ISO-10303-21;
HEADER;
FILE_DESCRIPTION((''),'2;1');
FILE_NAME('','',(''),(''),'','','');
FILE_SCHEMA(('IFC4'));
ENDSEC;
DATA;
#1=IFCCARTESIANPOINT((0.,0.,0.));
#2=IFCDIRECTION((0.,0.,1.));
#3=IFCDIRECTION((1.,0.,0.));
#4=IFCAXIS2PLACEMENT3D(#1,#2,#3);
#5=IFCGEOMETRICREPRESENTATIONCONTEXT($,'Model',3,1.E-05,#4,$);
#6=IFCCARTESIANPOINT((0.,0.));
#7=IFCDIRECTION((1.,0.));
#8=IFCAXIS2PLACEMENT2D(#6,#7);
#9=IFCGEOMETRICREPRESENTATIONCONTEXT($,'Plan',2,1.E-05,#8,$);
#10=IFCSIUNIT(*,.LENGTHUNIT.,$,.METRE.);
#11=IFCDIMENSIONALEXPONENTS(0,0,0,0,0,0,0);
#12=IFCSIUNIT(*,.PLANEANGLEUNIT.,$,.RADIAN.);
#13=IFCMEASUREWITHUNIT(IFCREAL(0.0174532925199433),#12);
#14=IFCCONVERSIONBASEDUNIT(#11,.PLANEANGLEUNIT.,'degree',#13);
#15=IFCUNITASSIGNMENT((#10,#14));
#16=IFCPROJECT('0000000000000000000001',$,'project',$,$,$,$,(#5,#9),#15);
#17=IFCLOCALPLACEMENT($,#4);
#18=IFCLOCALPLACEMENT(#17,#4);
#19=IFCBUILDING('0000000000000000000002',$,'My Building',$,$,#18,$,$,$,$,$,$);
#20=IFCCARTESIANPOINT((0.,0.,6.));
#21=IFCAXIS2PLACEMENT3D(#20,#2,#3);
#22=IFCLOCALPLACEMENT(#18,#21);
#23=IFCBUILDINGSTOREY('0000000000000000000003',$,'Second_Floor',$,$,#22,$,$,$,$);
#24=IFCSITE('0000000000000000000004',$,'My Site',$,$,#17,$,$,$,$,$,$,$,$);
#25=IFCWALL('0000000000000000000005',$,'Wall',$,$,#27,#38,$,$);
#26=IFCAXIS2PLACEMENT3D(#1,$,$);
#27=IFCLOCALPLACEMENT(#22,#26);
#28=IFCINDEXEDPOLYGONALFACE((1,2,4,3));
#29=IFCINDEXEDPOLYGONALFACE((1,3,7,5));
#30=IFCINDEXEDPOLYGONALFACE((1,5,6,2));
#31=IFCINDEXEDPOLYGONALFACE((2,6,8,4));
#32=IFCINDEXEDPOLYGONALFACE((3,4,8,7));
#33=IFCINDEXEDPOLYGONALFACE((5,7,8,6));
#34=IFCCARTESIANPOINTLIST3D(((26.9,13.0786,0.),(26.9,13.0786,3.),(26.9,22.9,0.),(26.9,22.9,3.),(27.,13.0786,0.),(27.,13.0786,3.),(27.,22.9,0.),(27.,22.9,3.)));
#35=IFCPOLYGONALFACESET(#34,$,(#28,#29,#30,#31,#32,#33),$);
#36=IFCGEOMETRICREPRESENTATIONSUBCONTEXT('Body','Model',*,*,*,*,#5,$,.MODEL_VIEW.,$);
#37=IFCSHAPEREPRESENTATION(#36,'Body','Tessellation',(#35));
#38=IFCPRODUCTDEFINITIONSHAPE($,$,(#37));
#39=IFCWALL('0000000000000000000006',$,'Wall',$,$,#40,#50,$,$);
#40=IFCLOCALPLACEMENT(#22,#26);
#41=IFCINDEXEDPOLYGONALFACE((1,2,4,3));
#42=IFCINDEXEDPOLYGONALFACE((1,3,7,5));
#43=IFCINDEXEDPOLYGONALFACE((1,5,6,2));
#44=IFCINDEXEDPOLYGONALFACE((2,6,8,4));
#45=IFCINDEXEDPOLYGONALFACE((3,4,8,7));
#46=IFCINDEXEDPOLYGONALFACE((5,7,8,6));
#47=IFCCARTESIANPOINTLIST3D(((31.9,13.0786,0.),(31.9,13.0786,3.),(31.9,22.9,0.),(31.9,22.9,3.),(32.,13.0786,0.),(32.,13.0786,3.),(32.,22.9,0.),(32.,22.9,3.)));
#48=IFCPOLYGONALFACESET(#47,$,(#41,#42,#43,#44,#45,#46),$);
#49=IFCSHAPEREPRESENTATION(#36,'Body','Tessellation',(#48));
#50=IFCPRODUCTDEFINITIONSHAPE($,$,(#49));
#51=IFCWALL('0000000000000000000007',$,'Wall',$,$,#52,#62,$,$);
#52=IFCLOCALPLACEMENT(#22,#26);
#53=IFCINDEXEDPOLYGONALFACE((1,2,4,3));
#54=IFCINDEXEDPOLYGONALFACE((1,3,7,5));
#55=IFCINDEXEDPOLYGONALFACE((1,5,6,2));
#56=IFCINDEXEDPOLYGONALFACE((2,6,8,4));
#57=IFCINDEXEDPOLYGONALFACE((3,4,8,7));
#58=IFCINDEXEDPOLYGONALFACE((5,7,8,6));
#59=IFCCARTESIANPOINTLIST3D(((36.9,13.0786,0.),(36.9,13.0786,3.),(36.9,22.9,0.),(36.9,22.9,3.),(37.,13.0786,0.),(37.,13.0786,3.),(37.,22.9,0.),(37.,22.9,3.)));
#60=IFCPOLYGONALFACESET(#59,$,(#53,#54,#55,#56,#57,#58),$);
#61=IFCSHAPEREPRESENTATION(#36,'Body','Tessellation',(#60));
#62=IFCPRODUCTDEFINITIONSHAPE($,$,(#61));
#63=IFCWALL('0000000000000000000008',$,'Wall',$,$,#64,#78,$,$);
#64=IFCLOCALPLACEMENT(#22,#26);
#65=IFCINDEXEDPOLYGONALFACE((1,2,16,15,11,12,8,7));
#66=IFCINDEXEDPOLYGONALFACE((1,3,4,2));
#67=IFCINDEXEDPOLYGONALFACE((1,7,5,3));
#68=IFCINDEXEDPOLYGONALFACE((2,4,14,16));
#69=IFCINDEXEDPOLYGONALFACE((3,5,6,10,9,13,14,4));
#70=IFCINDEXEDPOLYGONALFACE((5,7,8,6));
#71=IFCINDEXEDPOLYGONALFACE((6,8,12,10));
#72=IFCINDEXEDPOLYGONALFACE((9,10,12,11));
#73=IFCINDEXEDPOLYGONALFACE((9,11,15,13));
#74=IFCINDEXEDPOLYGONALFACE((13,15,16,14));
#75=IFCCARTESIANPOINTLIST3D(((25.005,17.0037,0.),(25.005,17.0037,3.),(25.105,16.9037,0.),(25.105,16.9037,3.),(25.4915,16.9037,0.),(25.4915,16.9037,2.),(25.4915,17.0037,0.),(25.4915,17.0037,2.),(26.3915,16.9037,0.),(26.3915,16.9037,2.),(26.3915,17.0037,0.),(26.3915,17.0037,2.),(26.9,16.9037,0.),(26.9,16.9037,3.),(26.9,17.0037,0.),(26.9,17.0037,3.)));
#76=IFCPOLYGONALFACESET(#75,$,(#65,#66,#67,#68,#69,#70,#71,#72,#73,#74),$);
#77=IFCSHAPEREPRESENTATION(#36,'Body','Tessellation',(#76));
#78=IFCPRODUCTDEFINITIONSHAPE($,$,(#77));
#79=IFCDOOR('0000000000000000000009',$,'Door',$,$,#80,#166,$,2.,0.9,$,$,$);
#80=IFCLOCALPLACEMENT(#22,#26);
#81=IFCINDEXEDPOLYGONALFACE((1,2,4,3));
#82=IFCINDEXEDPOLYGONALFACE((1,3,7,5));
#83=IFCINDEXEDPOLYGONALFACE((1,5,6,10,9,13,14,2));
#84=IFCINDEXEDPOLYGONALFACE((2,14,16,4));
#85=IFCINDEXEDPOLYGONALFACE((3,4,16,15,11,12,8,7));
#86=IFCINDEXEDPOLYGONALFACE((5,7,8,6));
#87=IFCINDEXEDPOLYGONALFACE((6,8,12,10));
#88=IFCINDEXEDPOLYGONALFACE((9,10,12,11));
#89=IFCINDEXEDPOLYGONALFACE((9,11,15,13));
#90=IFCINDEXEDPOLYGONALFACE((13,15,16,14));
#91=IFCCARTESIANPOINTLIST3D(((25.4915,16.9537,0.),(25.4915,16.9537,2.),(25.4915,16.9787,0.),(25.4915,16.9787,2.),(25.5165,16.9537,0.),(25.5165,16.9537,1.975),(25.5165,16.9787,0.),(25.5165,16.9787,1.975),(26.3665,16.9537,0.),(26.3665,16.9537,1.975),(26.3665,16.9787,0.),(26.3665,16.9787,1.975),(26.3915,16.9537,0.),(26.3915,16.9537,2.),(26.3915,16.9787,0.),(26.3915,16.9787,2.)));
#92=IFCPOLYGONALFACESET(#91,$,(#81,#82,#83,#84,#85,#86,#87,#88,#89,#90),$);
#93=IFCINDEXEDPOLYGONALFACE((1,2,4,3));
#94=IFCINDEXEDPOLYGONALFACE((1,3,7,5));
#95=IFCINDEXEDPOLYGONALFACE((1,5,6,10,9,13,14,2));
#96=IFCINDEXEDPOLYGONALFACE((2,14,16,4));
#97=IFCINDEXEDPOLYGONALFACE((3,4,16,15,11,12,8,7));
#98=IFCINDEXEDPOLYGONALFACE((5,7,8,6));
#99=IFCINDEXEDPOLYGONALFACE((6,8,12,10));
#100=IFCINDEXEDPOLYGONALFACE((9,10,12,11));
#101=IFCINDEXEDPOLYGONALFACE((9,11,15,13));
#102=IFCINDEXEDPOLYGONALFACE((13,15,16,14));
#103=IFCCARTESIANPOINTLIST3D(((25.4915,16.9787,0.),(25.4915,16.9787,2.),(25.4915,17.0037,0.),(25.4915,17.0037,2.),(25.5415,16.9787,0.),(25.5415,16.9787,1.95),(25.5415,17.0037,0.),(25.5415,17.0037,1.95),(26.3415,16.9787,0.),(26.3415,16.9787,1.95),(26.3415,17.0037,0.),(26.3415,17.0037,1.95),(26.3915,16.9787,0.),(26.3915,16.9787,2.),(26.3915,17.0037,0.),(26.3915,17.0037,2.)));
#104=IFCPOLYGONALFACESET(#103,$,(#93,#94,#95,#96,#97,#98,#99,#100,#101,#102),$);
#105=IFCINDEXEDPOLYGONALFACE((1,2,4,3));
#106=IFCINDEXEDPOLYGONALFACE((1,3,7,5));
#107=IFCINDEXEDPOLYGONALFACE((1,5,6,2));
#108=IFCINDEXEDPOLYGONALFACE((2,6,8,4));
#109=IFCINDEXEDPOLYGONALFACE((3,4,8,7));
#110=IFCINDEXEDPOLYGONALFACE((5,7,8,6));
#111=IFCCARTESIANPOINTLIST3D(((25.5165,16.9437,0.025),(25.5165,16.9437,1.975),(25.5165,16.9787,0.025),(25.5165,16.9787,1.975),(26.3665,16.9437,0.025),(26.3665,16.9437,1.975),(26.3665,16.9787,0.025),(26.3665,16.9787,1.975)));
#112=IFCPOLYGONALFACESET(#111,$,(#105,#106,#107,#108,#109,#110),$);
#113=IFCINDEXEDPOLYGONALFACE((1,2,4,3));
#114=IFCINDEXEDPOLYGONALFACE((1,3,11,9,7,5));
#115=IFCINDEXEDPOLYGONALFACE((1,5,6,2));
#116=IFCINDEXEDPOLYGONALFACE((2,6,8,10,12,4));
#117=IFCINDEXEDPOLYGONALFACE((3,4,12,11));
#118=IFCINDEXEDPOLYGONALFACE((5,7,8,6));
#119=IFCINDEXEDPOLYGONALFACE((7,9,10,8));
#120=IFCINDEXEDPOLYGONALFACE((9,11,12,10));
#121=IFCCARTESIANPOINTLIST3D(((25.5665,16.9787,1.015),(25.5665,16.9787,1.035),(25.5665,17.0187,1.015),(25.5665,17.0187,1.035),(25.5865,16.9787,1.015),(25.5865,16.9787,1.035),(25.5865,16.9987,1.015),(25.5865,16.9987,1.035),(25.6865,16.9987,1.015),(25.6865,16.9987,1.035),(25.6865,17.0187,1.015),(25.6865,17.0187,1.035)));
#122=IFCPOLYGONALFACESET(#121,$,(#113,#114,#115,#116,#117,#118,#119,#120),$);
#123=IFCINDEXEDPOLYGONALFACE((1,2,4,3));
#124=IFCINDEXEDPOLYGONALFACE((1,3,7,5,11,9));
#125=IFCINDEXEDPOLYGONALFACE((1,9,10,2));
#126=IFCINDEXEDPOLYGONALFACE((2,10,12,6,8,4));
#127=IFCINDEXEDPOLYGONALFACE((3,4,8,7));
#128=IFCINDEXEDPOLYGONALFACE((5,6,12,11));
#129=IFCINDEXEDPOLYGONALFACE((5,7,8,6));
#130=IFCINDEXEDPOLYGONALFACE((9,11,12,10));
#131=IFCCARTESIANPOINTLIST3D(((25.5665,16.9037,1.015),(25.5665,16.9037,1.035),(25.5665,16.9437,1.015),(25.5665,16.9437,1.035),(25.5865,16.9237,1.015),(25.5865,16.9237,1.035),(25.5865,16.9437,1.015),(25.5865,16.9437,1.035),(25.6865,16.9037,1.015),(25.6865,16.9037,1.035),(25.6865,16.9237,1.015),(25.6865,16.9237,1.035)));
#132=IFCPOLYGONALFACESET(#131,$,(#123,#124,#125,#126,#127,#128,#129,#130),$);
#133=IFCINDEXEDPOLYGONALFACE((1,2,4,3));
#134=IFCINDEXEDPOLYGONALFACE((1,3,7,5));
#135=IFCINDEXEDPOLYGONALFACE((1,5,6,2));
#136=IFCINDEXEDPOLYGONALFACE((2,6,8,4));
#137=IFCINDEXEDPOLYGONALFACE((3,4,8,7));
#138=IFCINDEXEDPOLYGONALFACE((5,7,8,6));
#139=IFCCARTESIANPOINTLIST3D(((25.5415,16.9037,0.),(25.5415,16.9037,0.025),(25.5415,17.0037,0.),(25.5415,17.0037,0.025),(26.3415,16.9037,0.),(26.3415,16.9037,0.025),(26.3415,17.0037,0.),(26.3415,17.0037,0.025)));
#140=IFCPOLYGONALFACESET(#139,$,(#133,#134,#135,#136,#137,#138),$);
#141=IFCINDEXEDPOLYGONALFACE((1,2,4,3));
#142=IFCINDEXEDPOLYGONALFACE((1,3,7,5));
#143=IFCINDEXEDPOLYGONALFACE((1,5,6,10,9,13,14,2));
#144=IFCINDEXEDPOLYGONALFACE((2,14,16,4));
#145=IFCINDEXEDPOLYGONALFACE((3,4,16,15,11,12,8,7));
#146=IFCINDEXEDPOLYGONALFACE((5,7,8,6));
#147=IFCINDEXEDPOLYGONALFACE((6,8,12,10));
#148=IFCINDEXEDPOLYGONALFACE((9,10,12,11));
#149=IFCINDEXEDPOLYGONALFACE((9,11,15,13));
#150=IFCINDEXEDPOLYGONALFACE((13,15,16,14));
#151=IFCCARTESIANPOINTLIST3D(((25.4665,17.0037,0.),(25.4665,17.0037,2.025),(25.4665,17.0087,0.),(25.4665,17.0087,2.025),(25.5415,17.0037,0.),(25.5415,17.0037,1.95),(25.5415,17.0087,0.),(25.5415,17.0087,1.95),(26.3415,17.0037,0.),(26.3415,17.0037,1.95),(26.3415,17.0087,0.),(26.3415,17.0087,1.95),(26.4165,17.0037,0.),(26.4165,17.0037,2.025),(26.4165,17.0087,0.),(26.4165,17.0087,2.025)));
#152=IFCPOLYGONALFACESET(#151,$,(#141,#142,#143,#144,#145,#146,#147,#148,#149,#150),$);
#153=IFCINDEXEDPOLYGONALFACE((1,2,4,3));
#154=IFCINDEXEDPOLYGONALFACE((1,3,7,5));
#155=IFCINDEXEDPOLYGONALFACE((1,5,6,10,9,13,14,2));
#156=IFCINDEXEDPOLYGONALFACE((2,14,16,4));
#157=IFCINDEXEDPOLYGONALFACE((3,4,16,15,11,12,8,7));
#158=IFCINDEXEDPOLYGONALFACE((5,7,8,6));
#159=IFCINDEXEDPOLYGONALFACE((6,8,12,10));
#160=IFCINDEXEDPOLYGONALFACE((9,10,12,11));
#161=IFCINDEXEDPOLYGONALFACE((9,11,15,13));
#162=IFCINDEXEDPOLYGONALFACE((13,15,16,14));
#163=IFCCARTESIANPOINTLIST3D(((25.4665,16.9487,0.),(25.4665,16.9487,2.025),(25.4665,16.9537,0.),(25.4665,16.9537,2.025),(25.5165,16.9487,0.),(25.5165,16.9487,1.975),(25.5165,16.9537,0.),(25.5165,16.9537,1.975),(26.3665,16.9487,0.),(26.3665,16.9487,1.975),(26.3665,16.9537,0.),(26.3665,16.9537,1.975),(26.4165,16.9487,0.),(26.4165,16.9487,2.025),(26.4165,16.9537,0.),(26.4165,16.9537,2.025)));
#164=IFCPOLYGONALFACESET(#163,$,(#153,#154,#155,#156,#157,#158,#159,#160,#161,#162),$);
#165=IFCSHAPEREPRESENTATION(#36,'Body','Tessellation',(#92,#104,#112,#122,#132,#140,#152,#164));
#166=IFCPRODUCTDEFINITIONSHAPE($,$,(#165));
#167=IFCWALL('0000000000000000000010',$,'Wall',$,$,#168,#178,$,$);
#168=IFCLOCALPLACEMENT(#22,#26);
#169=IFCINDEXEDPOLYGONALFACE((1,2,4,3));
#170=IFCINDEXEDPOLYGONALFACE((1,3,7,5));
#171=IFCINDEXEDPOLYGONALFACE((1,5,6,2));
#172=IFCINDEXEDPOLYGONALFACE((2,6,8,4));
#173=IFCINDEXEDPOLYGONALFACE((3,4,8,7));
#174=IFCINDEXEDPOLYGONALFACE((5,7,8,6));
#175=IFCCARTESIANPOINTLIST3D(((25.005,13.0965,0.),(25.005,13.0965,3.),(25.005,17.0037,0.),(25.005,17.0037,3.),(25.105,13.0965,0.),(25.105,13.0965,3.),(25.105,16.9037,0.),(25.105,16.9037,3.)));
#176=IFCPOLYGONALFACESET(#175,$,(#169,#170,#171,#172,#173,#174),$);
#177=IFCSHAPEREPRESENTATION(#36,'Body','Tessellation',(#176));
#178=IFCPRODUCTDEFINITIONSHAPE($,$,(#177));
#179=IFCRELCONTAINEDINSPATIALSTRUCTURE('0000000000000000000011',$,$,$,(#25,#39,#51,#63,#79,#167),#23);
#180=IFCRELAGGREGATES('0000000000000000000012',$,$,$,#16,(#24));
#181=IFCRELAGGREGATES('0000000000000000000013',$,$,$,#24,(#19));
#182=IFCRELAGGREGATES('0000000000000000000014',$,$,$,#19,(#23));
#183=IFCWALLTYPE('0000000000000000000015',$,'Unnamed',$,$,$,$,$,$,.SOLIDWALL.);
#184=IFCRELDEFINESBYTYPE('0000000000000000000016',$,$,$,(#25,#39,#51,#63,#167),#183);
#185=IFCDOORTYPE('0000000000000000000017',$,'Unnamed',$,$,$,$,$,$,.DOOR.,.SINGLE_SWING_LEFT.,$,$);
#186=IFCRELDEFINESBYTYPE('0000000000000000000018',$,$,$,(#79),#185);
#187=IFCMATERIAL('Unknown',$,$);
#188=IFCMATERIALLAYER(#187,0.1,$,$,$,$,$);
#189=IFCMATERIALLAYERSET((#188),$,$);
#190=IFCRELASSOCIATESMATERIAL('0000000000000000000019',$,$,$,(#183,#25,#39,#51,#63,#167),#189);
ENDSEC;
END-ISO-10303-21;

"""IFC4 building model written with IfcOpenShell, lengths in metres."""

from ifc_helpers import new_model, entity, si_unit, converted_unit, frame, origin_with_axes, origin_2d_with_axis, place, context, subcontext, project, spatial, line, indexed_curve, outline, extrude, shape, source, transform, mapped, material, layer, layer_set, layer_usage, type_object, type_shapes, element, fill, save


model = new_model("IFC4")

# Units and contexts
model_context = context("Model", 3, precision=1e-05, world=origin_with_axes())
plan_context = context("Plan", 2, precision=1e-05, world=origin_2d_with_axis())
body_context_1 = subcontext(model_context, "Body", "Model", "MODEL_VIEW")
body_context_2 = subcontext(plan_context, "Body", "Plan", "PLAN_VIEW")
ifc_project = project(units=[si_unit("LENGTHUNIT", "METRE"), converted_unit("PLANEANGLEUNIT", "degree", entity("IfcReal", 0.0174532925199433), si_unit("PLANEANGLEUNIT", "RADIAN"), dimensions=[0, 0, 0, 0, 0, 0, 0])], contexts=[model_context, plan_context])

# Site, building, storey
site_placement = place(None, origin_with_axes())
site = spatial("IfcSite", under=ifc_project, at=site_placement, Name="My Site")
building_placement = place(site_placement, origin_with_axes())
building = spatial("IfcBuilding", under=site, at=building_placement, Name="My Building")
storey_placement = place(building_placement, frame((0.0, 0.0, 6.0), z_axis=(0.0, 0.0, 1.0), x_axis=(1.0, 0.0, 0.0)))
storey = spatial("IfcBuildingStorey", under=building, at=storey_placement, Name="Second_Floor")

# Walls
ifc_material = material(Name="Unknown")
ifc_layer = layer(ifc_material, 0.1)
ifc_layer_set = layer_set([ifc_layer])
ifc_layer_usage_1 = layer_usage(ifc_layer_set, "AXIS2", "POSITIVE", 0.0)
wall_type = type_object("IfcWallType", Name="Unnamed", PredefinedType="SOLIDWALL", material=ifc_layer_set)
wall_1_placement = place(storey_placement, frame((26.9, 22.9, 0.0), z_axis=(0.0, 0.0, 1.0), x_axis=(0.0, -1.0, 0.0)))
element("IfcWall", 1, at=wall_1_placement, inside=storey, type_object=wall_type, material=ifc_layer_usage_1, Name="Wall", context=body_context_1, shape_type="SweptSolid", body=[
    extrude(outline(indexed_curve([(0.0, 0.0), (0.0, 0.1), (9.8214, 0.1), (9.8214, 0.0)], segments=[line(1, 2, 3, 4, 1)])), origin_with_axes(), (0.0, 0.0, 1.0), 3.0),
])
ifc_layer_usage_2 = layer_usage(ifc_layer_set, "AXIS2", "POSITIVE", 0.0)
wall_2_placement = place(storey_placement, frame((31.9, 22.9, 0.0), z_axis=(0.0, 0.0, 1.0), x_axis=(0.0, -1.0, 0.0)))
element("IfcWall", 2, at=wall_2_placement, inside=storey, type_object=wall_type, material=ifc_layer_usage_2, Name="Wall", context=body_context_1, shape_type="SweptSolid", body=[
    extrude(outline(indexed_curve([(0.0, 0.0), (0.0, 0.1), (9.8214, 0.1), (9.8214, 0.0)], segments=[line(1, 2, 3, 4, 1)])), origin_with_axes(), (0.0, 0.0, 1.0), 3.0),
])
ifc_layer_usage_3 = layer_usage(ifc_layer_set, "AXIS2", "POSITIVE", 0.0)
wall_3_placement = place(storey_placement, frame((36.9, 22.9, 0.0), z_axis=(0.0, 0.0, 1.0), x_axis=(0.0, -1.0, 0.0)))
element("IfcWall", 3, at=wall_3_placement, inside=storey, type_object=wall_type, material=ifc_layer_usage_3, Name="Wall", context=body_context_1, shape_type="SweptSolid", body=[
    extrude(outline(indexed_curve([(0.0, 0.0), (0.0, 0.1), (9.8214, 0.1), (9.8214, 0.0)], segments=[line(1, 2, 3, 4, 1)])), origin_with_axes(), (0.0, 0.0, 1.0), 3.0),
])

# Wall, opening, door
ifc_layer_usage_4 = layer_usage(ifc_layer_set, "AXIS2", "POSITIVE", 0.0)
wall_4_placement = place(storey_placement, frame((26.9, 17.0037, 0.0), z_axis=(0.0, 0.0, 1.0), x_axis=(-1.0, 0.0, 0.0)))
wall_4 = element("IfcWall", 4, at=wall_4_placement, inside=storey, type_object=wall_type, material=ifc_layer_usage_4, Name="Wall", context=body_context_1, shape_type="SweptSolid", body=[
    extrude(outline(indexed_curve([(0.0, 0.0), (0.0, 0.1), (1.795, 0.1), (1.895, 0.0)], segments=[line(1, 2, 3, 4, 1)])), origin_with_axes(), (0.0, 0.0, 1.0), 3.0),
])
shared_shape_1 = source(origin_with_axes(), body_context_1, "Body", "SweptSolid", [
    extrude(outline(indexed_curve([(0.0, 0.0), (0.9, 0.0), (0.9, 2.0), (0.0, 2.0)], segments=[line(1, 2, 3, 4, 1)])), frame((0.0, -0.6, 0.0), z_axis=(0.0, -1.0, 0.0), x_axis=(1.0, 0.0, 0.0)), (0.0, 0.0, -1.0), 1.2),
])
opening_1_placement = place(wall_4_placement, frame((0.5085, 0.0, 0.0), z_axis=(0.0, 0.0, 1.0), x_axis=(1.0, 0.0, 0.0)))
opening_1 = element("IfcOpeningElement", 5, at=opening_1_placement, cuts=wall_4, PredefinedType="OPENING", context=body_context_1, shape_type="MappedRepresentation", body=[
    mapped(shared_shape_1, transform((0.0, 0.0, 0.0), x_axis=(1.0, 0.0, 0.0), y_axis=(0.0, 1.0, 0.0), z_axis=(0.0, 0.0, 1.0), scale=1.0)),
])
door_type = type_object("IfcDoorType", Name="Unnamed", OperationType="SINGLE_SWING_LEFT", PredefinedType="DOOR")
shared_shape_2 = source(origin_with_axes(), body_context_1, "Body", "SweptSolid", [
    extrude(outline(indexed_curve([(0.0, 0.0), (0.0, 2.0), (0.9, 2.0), (0.9, 0.0), (0.875, 0.0), (0.875, 1.975), (0.025, 1.975), (0.025, 0.0)], segments=[line(1, 2, 3, 4, 5, 6, 7, 8, 1)])), frame((0.0, 0.025, 0.0), z_axis=(0.0, -1.0, 0.0), x_axis=(1.0, 0.0, 0.0)), (0.0, 0.0, -1.0), 0.025),
    extrude(outline(indexed_curve([(0.0, 0.0), (0.0, 2.0), (0.9, 2.0), (0.9, 0.0), (0.85, 0.0), (0.85, 1.95), (0.05, 1.95), (0.05, 0.0)], segments=[line(1, 2, 3, 4, 5, 6, 7, 8, 1)])), frame((0.0, 0.0, 0.0), z_axis=(0.0, -1.0, 0.0), x_axis=(1.0, 0.0, 0.0)), (0.0, 0.0, -1.0), 0.025),
    extrude(outline(indexed_curve([(0.0, 0.0), (0.85, 0.0), (0.85, 0.035), (0.0, 0.035)], segments=[line(1, 2, 3, 4, 1)])), frame((0.025, 0.025, 0.025), z_axis=(0.0, 0.0, 1.0), x_axis=(1.0, 0.0, 0.0)), (0.0, 0.0, 1.0), 1.95),
    extrude(outline(indexed_curve([(0.0, 0.0), (0.0, -0.04), (-0.12, -0.04), (-0.12, -0.02), (-0.02, -0.02), (-0.02, 0.0)], segments=[line(1, 2, 3, 4, 5, 6, 1)])), frame((0.825, 0.025, 1.015), z_axis=(0.0, 0.0, 1.0), x_axis=(1.0, 0.0, 0.0)), (0.0, 0.0, 1.0), 0.02),
    extrude(outline(indexed_curve([(0.0, 0.0), (0.0, 0.04), (-0.12, 0.04), (-0.12, 0.02), (-0.02, 0.02), (-0.02, 0.0)], segments=[line(1, 2, 3, 4, 5, 6, 1)])), frame((0.825, 0.06, 1.015), z_axis=(0.0, 0.0, 1.0), x_axis=(1.0, 0.0, 0.0)), (0.0, 0.0, 1.0), 0.02),
    extrude(outline(indexed_curve([(0.0, 0.0), (0.8, 0.0), (0.8, 0.1), (0.0, 0.1)], segments=[line(1, 2, 3, 4, 1)])), frame((0.05, 0.0, 0.0), z_axis=(0.0, 0.0, 1.0), x_axis=(1.0, 0.0, 0.0)), (0.0, 0.0, 1.0), 0.025),
    extrude(outline(indexed_curve([(0.0, 0.0), (0.0, 2.025), (0.95, 2.025), (0.95, 0.0), (0.875, 0.0), (0.875, 1.95), (0.075, 1.95), (0.075, 0.0)], segments=[line(1, 2, 3, 4, 5, 6, 7, 8, 1)])), frame((-0.025, -0.005, 0.0), z_axis=(0.0, -1.0, 0.0), x_axis=(1.0, 0.0, 0.0)), (0.0, 0.0, -1.0), 0.005),
    extrude(outline(indexed_curve([(0.0, 0.0), (0.0, 2.025), (0.95, 2.025), (0.95, 0.0), (0.9, 0.0), (0.9, 1.975), (0.05, 1.975), (0.05, 0.0)], segments=[line(1, 2, 3, 4, 5, 6, 7, 8, 1)])), frame((-0.025, 0.05, 0.0), z_axis=(0.0, -1.0, 0.0), x_axis=(1.0, 0.0, 0.0)), (0.0, 0.0, -1.0), 0.005),
])
shared_shape_3 = source(origin_with_axes(), body_context_2, "Body", "Curve2D", [
    entity("IfcIndexedPolyCurve", entity("IfcCartesianPointList2D", [[0.0, 0.0], [0.0, 0.05], [0.025, 0.05], [0.025, 0.025], [0.05, 0.025], [0.05, 0.0]]), [entity("IfcLineIndex", [1, 2, 3, 4, 5, 6, 1])]),
    entity("IfcIndexedPolyCurve", entity("IfcCartesianPointList2D", [[0.9, 0.0], [0.9, 0.05], [0.875, 0.05], [0.875, 0.025], [0.85, 0.025], [0.85, 0.0]]), [entity("IfcLineIndex", [1, 2, 3, 4, 5, 6, 1])]),
    entity("IfcTrimmedCurve", entity("IfcEllipse", entity("IfcAxis2Placement2D", entity("IfcCartesianPoint", [0.06, 0.05]), entity("IfcDirection", [1.0, 0.0])), 0.815, 0.85), [entity("IfcCartesianPoint", [0.875, 0.05])], [entity("IfcCartesianPoint", [0.06, 0.9])], True, "CARTESIAN"),
    entity("IfcIndexedPolyCurve", entity("IfcCartesianPointList2D", [[0.025, 0.05], [0.06, 0.05], [0.06, 0.9], [0.025, 0.9]]), [entity("IfcLineIndex", [1, 2, 3, 4, 1])]),
])
type_shapes(door_type, [shared_shape_2, shared_shape_3])
door_1_placement = place(opening_1_placement, frame((0.0, 0.0, 0.0), z_axis=(0.0, 0.0, 1.0), x_axis=(1.0, 0.0, 0.0)))
door_1 = element("IfcDoor", 6, at=door_1_placement, inside=storey, type_object=door_type, Name="Door", OverallHeight=2.0, OverallWidth=0.9, shapes=[
    shape(body_context_1, "Body", "MappedRepresentation", [mapped(shared_shape_2, transform((0.0, 0.0, 0.0), x_axis=(1.0, 0.0, 0.0), y_axis=(0.0, 1.0, 0.0), z_axis=(0.0, 0.0, 1.0), scale=1.0))]),
    shape(body_context_2, "Body", "MappedRepresentation", [mapped(shared_shape_3, transform((0.0, 0.0, 0.0), x_axis=(1.0, 0.0, 0.0), y_axis=(0.0, 1.0, 0.0), z_axis=(0.0, 0.0, 1.0), scale=1.0))]),
])
fill(opening_1, door_1)

# Wall
ifc_layer_usage_5 = layer_usage(ifc_layer_set, "AXIS2", "POSITIVE", 0.0)
wall_5_placement = place(storey_placement, frame((25.005, 17.0037, 0.0), z_axis=(0.0, 0.0, 1.0), x_axis=(0.0, -1.0, 0.0)))
element("IfcWall", 7, at=wall_5_placement, inside=storey, type_object=wall_type, material=ifc_layer_usage_5, Name="Wall", context=body_context_1, shape_type="SweptSolid", body=[
    extrude(outline(indexed_curve([(0.0, 0.0), (0.1, 0.1), (3.9072, 0.1), (3.9072, 0.0)], segments=[line(1, 2, 3, 4, 1)])), origin_with_axes(), (0.0, 0.0, 1.0), 3.0),
])

save(model, "model.ifc")
